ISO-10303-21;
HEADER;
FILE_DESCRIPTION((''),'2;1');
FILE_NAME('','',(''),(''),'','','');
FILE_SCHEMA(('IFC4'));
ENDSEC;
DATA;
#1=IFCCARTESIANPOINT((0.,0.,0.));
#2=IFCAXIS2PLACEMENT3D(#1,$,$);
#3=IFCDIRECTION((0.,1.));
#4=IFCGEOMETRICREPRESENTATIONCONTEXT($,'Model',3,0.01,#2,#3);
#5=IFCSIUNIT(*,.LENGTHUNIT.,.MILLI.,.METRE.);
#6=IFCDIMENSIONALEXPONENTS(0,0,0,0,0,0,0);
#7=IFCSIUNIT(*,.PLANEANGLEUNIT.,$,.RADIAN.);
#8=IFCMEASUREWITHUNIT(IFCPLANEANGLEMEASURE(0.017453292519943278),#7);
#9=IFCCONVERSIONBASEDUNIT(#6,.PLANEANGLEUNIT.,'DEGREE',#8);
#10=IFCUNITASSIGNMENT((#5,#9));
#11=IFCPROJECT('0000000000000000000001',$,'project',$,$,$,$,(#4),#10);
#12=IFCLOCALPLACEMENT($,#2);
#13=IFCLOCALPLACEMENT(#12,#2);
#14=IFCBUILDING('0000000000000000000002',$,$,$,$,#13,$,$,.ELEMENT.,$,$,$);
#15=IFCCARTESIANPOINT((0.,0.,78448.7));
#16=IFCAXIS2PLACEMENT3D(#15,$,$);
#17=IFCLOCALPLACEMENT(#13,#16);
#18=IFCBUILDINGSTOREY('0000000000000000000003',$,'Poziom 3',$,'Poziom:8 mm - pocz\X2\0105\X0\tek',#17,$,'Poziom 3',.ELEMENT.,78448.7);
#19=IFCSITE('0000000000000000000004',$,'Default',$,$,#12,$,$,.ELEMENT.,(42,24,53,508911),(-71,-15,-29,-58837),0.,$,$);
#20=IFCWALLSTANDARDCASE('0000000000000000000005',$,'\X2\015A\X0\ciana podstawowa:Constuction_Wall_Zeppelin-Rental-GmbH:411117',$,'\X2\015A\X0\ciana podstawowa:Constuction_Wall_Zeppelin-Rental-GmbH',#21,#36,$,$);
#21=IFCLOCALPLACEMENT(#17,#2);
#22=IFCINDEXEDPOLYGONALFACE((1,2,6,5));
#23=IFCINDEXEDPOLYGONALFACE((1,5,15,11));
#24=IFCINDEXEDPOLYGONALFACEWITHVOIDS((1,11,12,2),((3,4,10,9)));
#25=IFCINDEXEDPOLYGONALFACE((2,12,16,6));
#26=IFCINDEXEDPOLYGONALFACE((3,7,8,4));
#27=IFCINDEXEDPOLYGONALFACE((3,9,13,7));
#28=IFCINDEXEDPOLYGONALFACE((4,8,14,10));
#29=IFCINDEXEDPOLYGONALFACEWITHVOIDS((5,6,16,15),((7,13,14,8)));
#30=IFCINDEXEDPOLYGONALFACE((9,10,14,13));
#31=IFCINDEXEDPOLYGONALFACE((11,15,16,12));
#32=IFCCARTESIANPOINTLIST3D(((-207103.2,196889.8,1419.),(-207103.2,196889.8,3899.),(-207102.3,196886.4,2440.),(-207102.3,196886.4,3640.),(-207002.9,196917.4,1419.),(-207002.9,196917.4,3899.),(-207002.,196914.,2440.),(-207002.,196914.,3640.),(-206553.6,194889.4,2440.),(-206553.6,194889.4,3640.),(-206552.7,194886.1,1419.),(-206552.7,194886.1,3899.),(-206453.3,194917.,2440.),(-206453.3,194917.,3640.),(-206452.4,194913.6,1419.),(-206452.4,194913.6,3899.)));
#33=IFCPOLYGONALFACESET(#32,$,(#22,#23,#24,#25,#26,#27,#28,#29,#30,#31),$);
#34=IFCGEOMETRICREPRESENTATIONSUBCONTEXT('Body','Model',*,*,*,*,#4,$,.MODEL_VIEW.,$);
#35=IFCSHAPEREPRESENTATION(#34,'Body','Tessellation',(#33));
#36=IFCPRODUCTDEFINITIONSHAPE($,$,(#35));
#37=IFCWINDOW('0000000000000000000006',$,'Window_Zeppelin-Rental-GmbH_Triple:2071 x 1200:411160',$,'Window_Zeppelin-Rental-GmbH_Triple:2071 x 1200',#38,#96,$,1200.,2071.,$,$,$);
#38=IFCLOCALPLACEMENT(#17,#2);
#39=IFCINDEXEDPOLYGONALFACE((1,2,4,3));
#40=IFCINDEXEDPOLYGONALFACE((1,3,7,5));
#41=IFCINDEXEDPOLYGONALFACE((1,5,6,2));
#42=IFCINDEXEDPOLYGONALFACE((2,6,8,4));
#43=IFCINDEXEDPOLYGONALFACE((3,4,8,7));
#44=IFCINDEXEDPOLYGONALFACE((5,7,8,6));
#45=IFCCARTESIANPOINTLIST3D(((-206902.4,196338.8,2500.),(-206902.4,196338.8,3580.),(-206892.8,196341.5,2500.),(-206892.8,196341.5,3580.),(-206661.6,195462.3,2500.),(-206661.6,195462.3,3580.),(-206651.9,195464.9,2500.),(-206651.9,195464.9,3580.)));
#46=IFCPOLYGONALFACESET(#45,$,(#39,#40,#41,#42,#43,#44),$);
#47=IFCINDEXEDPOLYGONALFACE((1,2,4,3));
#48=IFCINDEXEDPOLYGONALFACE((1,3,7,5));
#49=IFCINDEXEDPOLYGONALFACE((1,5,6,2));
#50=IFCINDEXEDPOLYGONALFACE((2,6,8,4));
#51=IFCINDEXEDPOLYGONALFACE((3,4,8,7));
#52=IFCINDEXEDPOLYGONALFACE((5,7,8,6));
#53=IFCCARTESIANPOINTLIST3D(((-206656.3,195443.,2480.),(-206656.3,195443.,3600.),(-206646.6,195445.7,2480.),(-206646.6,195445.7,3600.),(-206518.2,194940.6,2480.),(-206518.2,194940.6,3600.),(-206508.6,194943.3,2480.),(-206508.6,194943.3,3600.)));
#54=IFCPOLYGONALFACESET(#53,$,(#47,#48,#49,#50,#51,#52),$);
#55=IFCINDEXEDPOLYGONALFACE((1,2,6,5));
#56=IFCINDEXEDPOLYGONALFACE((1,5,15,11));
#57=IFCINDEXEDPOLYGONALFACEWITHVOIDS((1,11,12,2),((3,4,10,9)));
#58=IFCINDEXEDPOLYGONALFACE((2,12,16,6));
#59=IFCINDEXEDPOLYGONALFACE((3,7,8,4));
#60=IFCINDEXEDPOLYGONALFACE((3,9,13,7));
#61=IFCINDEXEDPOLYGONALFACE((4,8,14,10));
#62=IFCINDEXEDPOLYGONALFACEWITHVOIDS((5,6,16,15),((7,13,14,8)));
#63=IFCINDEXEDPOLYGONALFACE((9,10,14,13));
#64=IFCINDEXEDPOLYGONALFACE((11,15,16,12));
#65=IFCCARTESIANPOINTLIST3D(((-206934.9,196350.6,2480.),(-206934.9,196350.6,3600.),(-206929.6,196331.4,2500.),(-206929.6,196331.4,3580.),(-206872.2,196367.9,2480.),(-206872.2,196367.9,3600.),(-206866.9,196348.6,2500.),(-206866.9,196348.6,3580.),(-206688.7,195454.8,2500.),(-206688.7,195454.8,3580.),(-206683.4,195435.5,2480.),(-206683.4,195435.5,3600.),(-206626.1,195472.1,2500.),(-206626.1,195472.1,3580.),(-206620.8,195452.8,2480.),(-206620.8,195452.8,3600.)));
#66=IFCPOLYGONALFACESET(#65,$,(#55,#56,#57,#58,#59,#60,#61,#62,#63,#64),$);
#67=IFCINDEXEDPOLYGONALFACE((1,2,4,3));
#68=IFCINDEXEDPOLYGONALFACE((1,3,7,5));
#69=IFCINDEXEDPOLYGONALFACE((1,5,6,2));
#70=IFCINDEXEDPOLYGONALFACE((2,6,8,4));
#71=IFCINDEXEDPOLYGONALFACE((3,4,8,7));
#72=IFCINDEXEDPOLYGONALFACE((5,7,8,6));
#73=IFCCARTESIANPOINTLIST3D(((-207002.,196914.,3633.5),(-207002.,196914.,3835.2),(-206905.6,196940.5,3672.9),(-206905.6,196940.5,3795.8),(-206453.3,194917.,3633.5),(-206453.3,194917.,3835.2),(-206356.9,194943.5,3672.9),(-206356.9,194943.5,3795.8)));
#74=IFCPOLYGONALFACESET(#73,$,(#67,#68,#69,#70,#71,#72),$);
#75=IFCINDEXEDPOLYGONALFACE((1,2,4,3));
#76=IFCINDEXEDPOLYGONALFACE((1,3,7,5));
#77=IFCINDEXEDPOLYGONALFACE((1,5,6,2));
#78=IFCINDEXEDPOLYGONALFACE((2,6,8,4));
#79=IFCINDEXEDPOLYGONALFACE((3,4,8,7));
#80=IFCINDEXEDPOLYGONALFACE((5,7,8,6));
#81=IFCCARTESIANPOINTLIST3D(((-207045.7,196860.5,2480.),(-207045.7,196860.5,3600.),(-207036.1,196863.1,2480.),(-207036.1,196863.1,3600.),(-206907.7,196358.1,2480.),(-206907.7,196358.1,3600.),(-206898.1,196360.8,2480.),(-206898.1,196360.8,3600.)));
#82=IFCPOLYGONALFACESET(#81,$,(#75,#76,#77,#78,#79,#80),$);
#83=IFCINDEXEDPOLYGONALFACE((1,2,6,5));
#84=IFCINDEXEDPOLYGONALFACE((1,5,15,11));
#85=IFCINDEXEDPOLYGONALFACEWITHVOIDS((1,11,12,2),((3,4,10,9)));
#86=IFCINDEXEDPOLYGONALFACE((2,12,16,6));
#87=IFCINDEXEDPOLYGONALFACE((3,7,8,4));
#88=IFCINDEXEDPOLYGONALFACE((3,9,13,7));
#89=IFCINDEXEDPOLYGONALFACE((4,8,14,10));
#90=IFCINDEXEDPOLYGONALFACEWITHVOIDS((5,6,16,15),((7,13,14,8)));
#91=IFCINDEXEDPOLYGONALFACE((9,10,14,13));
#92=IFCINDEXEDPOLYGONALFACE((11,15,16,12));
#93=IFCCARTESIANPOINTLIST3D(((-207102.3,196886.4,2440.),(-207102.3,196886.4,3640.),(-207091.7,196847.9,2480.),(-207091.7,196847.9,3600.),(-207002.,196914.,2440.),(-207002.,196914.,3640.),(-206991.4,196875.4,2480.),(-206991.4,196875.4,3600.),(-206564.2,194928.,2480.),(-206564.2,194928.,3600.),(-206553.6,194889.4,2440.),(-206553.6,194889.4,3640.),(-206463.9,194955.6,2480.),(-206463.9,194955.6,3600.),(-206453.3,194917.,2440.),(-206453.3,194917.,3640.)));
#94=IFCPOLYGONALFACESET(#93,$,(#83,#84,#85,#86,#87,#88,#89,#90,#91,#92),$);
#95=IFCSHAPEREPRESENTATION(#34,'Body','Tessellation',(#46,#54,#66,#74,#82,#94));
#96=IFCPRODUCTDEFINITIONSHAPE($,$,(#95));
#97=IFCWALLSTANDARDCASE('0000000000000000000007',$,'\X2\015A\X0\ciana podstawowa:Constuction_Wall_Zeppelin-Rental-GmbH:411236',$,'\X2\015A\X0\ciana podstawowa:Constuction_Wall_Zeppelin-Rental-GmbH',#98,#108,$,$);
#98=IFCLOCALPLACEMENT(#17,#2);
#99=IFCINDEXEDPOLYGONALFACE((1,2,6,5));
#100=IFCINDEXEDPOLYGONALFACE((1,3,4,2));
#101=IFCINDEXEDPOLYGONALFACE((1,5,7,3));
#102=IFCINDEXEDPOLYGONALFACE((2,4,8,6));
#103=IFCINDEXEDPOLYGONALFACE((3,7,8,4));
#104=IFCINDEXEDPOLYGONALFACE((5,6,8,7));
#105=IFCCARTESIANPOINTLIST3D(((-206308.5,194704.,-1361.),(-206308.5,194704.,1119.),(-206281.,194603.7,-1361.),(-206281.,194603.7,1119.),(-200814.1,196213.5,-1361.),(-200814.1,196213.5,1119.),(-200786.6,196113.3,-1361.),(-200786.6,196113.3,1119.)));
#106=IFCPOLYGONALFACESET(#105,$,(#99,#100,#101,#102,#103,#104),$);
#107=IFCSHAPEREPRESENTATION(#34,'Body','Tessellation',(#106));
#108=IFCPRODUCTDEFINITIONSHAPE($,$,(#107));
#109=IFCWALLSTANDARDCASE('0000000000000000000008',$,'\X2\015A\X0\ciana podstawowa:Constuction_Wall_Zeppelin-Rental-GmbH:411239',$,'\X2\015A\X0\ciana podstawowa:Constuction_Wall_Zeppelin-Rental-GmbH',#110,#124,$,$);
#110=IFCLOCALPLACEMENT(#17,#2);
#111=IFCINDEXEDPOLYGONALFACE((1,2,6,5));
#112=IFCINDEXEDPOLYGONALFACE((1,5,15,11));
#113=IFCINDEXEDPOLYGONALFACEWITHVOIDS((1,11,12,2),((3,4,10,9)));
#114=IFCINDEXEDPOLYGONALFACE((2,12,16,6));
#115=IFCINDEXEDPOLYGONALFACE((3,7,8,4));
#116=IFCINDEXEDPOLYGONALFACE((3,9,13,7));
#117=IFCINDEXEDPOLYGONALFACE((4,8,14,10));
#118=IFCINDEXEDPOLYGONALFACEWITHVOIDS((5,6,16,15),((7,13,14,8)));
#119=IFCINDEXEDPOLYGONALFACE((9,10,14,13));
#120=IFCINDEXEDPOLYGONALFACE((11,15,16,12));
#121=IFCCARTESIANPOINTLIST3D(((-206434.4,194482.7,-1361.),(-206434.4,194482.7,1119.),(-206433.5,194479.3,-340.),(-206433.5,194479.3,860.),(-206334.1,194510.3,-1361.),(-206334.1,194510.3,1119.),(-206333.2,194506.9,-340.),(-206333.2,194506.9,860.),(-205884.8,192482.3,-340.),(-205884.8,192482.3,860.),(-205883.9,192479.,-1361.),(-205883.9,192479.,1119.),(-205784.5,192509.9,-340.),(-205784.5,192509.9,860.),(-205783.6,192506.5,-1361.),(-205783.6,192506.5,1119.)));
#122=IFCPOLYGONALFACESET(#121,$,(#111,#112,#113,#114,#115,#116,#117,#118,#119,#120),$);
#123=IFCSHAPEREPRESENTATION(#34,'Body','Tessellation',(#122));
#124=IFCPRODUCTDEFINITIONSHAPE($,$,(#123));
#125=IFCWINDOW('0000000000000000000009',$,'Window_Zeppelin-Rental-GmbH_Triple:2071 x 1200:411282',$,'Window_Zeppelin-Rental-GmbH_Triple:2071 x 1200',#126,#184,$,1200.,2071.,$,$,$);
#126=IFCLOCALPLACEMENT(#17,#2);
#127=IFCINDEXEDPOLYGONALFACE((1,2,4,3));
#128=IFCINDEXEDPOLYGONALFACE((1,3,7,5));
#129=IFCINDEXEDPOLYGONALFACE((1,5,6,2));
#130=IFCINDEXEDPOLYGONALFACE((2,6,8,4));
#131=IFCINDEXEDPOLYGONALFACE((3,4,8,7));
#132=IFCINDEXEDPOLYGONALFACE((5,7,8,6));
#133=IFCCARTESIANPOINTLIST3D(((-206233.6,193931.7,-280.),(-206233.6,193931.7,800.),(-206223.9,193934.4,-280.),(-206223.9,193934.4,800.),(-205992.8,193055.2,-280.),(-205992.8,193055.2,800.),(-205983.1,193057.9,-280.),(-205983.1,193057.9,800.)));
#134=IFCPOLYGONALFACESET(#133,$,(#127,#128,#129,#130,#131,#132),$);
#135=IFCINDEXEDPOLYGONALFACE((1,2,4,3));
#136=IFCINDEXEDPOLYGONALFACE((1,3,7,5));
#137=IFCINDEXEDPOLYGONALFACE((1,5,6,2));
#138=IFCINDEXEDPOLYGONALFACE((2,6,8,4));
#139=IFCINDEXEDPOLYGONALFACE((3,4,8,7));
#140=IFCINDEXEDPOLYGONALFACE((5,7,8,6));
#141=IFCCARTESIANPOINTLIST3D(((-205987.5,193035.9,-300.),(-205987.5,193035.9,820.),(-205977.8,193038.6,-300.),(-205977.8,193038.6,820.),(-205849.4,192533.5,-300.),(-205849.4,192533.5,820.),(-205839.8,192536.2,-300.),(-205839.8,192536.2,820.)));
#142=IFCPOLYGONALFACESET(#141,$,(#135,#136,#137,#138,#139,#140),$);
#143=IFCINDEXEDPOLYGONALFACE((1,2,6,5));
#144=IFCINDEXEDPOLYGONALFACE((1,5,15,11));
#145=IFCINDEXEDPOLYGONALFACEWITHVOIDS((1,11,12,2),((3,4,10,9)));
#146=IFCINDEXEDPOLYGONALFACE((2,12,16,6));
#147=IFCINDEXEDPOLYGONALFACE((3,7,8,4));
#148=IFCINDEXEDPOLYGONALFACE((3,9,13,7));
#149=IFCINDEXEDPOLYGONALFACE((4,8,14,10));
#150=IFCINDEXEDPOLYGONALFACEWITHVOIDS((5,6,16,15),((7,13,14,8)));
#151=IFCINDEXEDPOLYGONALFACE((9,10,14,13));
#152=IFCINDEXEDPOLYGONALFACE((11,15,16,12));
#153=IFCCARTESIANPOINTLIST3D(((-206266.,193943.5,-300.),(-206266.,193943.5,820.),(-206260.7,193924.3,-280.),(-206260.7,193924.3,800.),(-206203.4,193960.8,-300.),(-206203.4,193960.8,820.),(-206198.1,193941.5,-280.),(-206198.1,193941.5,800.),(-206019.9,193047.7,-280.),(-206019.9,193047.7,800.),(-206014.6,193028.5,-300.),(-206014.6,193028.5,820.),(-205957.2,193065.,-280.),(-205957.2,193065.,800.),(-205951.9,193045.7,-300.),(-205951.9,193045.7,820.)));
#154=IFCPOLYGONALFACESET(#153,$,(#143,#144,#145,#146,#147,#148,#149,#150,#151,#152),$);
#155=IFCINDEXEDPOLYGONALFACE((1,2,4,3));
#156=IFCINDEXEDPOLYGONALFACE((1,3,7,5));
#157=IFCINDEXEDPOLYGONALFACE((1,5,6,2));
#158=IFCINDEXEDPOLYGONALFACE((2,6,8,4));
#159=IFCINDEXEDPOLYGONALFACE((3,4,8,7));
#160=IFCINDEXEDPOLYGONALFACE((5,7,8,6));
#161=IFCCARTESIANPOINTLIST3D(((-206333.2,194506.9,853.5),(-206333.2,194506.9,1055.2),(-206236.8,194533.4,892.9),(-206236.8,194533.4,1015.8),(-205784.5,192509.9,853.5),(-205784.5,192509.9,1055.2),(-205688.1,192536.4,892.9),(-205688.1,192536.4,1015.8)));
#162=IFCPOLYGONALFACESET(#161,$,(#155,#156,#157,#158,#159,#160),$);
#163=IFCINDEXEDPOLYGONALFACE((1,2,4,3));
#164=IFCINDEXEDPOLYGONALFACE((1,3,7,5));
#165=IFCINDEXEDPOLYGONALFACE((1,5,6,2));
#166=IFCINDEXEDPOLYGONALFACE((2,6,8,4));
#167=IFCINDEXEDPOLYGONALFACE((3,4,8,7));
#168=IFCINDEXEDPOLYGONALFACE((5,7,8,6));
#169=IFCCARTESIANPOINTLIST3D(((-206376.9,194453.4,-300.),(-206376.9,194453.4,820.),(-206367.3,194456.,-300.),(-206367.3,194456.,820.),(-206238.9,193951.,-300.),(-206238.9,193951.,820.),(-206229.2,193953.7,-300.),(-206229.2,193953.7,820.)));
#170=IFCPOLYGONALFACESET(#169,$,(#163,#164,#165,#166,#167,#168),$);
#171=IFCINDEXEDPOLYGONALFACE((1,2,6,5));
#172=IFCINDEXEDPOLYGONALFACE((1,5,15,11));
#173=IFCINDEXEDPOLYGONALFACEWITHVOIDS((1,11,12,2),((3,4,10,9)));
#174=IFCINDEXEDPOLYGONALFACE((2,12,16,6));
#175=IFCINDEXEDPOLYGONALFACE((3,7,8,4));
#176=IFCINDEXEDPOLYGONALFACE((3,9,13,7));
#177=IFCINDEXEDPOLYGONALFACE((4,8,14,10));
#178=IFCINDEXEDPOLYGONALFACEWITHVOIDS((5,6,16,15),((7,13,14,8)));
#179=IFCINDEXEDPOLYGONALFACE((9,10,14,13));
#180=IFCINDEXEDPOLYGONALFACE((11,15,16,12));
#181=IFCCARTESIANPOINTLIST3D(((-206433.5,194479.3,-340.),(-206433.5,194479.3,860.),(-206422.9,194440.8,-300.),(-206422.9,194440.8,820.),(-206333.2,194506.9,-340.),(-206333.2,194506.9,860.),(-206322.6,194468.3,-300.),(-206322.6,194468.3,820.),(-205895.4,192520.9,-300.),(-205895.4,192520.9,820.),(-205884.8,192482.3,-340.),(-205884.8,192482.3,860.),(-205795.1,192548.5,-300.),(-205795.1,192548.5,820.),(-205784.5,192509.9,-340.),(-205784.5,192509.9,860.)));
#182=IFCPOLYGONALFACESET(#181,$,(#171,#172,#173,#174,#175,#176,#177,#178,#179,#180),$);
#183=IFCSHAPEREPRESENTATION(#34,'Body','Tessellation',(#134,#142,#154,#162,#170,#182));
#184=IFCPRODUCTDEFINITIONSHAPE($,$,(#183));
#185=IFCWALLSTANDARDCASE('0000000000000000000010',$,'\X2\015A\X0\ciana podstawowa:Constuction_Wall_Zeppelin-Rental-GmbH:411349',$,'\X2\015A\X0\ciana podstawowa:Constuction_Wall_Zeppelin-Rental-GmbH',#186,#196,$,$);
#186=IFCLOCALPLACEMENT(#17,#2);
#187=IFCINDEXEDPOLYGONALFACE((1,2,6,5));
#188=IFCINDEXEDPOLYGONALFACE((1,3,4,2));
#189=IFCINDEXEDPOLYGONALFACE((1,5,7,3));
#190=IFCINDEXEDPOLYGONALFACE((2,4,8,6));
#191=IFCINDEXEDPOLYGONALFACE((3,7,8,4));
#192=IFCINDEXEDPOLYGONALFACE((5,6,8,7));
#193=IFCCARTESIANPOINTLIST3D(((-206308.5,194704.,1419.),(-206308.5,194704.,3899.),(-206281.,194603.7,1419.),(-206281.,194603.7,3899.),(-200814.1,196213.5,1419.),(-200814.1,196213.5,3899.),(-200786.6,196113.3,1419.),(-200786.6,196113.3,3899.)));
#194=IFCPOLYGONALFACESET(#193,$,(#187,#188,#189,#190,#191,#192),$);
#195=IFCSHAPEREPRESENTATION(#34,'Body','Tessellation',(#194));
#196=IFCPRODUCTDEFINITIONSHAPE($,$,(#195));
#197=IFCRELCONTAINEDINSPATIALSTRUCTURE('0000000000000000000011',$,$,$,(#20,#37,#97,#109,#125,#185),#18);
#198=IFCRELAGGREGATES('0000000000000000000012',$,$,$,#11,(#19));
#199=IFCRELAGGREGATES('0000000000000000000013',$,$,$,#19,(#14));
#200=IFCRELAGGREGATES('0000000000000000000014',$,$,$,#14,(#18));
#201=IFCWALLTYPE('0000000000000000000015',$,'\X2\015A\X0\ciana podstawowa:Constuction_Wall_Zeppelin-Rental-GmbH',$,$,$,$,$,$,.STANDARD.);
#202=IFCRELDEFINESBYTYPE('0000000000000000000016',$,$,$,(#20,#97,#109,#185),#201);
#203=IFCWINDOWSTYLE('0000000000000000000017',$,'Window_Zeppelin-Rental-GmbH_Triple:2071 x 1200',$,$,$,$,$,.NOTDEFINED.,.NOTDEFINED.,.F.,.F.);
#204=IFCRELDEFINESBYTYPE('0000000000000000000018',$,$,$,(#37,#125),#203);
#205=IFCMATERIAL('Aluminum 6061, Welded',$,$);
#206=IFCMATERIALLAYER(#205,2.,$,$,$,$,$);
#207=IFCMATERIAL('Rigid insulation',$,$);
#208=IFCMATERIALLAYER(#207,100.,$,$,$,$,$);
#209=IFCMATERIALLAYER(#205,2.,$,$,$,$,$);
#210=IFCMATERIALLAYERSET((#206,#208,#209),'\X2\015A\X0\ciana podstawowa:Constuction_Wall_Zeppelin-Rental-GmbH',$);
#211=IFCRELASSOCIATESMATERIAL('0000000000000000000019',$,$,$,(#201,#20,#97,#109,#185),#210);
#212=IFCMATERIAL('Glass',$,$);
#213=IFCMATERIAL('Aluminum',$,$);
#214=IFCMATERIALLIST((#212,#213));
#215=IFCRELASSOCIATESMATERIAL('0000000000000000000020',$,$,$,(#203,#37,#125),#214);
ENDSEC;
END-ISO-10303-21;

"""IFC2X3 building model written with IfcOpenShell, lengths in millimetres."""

from ifc_helpers import new_model, entity, si_unit, converted_unit, direction, frame, frame_2d, origin, origin_2d_with_axis, place, context, subcontext, project, spatial, polyline, rectangle, outline, extrude, source, transform, mapped, material, material_list, layer, layer_set, layer_usage, type_object, type_shapes, element, fill, save


model = new_model("IFC2X3")

# Units and contexts
model_context = context("Model", 3, precision=0.01, world=origin(), true_north=direction((0.0, 1.0)))
body_context = subcontext(model_context, "Body", "Model", "MODEL_VIEW")
ifc_project = project(units=[si_unit("LENGTHUNIT", "METRE", prefix="MILLI"), converted_unit("PLANEANGLEUNIT", "DEGREE", entity("IfcPlaneAngleMeasure", 0.017453292519943278), si_unit("PLANEANGLEUNIT", "RADIAN"), dimensions=[0, 0, 0, 0, 0, 0, 0])], contexts=[model_context])

# Site, building, storey
site_placement = place(None, origin())
site = spatial("IfcSite", under=ifc_project, at=site_placement, Name="Default", CompositionType="ELEMENT", RefLatitude=(42, 24, 53, 508911), RefLongitude=(-71, -15, -29, -58837), RefElevation=0.0)
building_placement = place(site_placement, origin())
building = spatial("IfcBuilding", under=site, at=building_placement, CompositionType="ELEMENT")
storey_placement = place(building_placement, frame((0.0, 0.0, 78448.7)))
storey = spatial("IfcBuildingStorey", under=building, at=storey_placement, Name="Poziom 3", ObjectType="Poziom:8 mm - początek", LongName="Poziom 3", CompositionType="ELEMENT", Elevation=78448.7)

# Shared definitions
ifc_material_1 = material(Name="Aluminum 6061, Welded")
ifc_layer_1 = layer(ifc_material_1, 2.0)
ifc_material_2 = material(Name="Rigid insulation")
ifc_layer_2 = layer(ifc_material_2, 100.0)
ifc_layer_3 = layer(ifc_material_1, 2.0)
ifc_layer_set_1 = layer_set([ifc_layer_1, ifc_layer_2, ifc_layer_3], Name="Ściana podstawowa:Constuction_Wall_Zeppelin-Rental-GmbH")
wall_type_1 = type_object("IfcWallType", Name="Ściana podstawowa:Constuction_Wall_Zeppelin-Rental-GmbH", PredefinedType="STANDARD", material=ifc_layer_set_1)

# Shared definitions
ifc_material_3 = material(Name="Glass")
ifc_material_4 = material(Name="Aluminum")
ifc_material_list = material_list([ifc_material_3, ifc_material_4])
window_style = type_object("IfcWindowStyle", Name="Window_Zeppelin-Rental-GmbH_Triple:2071 x 1200", ConstructionType="NOTDEFINED", OperationType="NOTDEFINED", ParameterTakesPrecedence=False, Sizeable=False, material=ifc_material_list)
shared_shape_1 = source(origin(), body_context, "Body", "SweptSolid", [
    extrude(rectangle(XDim=10.0, YDim=909.0, at=origin_2d_with_axis()), frame((1035.5, 52.7, 60.0), z_axis=(0.0, 0.0, 1.0), x_axis=(0.0, -1.0, 0.0)), (0.0, 0.0, 1.0), 1080.0),
    extrude(rectangle(XDim=521.0, YDim=10.0, at=frame_2d((0.0, 0.0), x_axis=(1.0, 0.0))), frame((300.5, 52.7, 40.0), z_axis=(0.0, 0.0, 1.0), x_axis=(-1.0, 0.0, 0.0)), (0.0, 0.0, 1.0), 1120.0),
    extrude(outline(polyline([(-474.5, -560.0), (474.5, -560.0), (474.5, 560.0), (-474.5, 560.0), (-474.5, -560.0)]), holes=[polyline([(-454.5, 540.0), (454.5, 540.0), (454.5, -540.0), (-454.5, -540.0), (-454.5, 540.0)])]), frame((1035.5, 85.8, 600.0), z_axis=(0.0, -1.0, 0.0), x_axis=(1.0, 0.0, 0.0)), (0.0, 0.0, 1.0), 65.0),
    extrude(outline(polyline([(-24.0, -75.5), (83.5, -75.5), (9.6, 112.1), (-69.0, 38.9), (-24.0, -75.5)])), frame((2071.0, -48.7, 1294.4), z_axis=(-1.0, 0.0, 0.0), x_axis=(0.0, 0.930458, 0.366398)), (0.0, 0.0, 1.0), 2071.0),
    extrude(rectangle(XDim=10.0, YDim=521.0, at=frame_2d((0.0, 0.0), x_axis=(1.0, 0.0))), frame((1770.5, 52.7, 40.0), z_axis=(0.0, 0.0, 1.0), x_axis=(0.0, -1.0, 0.0)), (0.0, 0.0, 1.0), 1120.0),
    extrude(outline(polyline([(-1035.5, -600.0), (1035.5, -600.0), (1035.5, 600.0), (-1035.5, 600.0), (-1035.5, -600.0)]), holes=[polyline([(-995.5, 560.0), (995.5, 560.0), (995.5, -560.0), (-995.5, -560.0), (-995.5, 560.0)])]), frame((1035.5, 105.3, 600.0), z_axis=(0.0, -1.0, 0.0), x_axis=(1.0, 0.0, 0.0)), (0.0, 0.0, 1.0), 104.0),
])
type_shapes(window_style, [shared_shape_1])

# Wall, opening, window
ifc_layer_usage_1 = layer_usage(ifc_layer_set_1, "AXIS2", "NEGATIVE", 52.0)
wall_1_placement = place(storey_placement, frame((-206502.5, 194899.8, 1419.0), z_axis=(0.0, 0.0, 1.0), x_axis=(-0.264931, 0.964267, 0.0)))
wall_1 = element("IfcWallStandardCase", 1, at=wall_1_placement, inside=storey, type_object=wall_type_1, material=ifc_layer_usage_1, Name="Ściana podstawowa:Constuction_Wall_Zeppelin-Rental-GmbH:411117", ObjectType="Ściana podstawowa:Constuction_Wall_Zeppelin-Rental-GmbH", context=body_context, shape_type="SweptSolid", body=[
    extrude(rectangle(XDim=2078.0, YDim=104.0, at=frame_2d((1039.0, 0.0), x_axis=(-1.0, 0.0))), origin(), (0.0, 0.0, 1.0), 2480.0),
])
opening_1_placement = place(wall_1_placement, frame((3.5, -52.0, 1021.0)))
opening_1 = element("IfcOpeningElement", 2, at=opening_1_placement, cuts=wall_1, ObjectType="Opening", context=body_context, shape_type="SweptSolid", body=[
    extrude(rectangle(XDim=1200.0, YDim=2071.0, at=frame_2d((600.0, 1035.5), x_axis=(1.0, 0.0))), frame((0.0, 0.0, 0.0), z_axis=(0.0, 1.0, 0.0), x_axis=(0.0, 0.0, 1.0)), (0.0, 0.0, 1.0), 104.0),
])
window_1_placement = place(opening_1_placement, frame((0.0, -1.3, 0.0)))
window_1 = element("IfcWindow", 3, at=window_1_placement, inside=storey, type_object=window_style, material=ifc_material_list, Name="Window_Zeppelin-Rental-GmbH_Triple:2071 x 1200:411160", ObjectType="Window_Zeppelin-Rental-GmbH_Triple:2071 x 1200", OverallHeight=1200.0, OverallWidth=2071.0, context=body_context, shape_type="MappedRepresentation", body=[
    mapped(shared_shape_1, transform((0.0, 0.0, 0.0), scale=1.0)),
])
fill(opening_1, window_1)

# Wall
ifc_layer_usage_2 = layer_usage(ifc_layer_set_1, "AXIS2", "NEGATIVE", 52.0)
wall_2_placement = place(storey_placement, frame((-206294.7, 194653.8, -1361.0), z_axis=(0.0, 0.0, 1.0), x_axis=(0.964267, 0.264931, 0.0)))
element("IfcWallStandardCase", 4, at=wall_2_placement, inside=storey, type_object=wall_type_1, material=ifc_layer_usage_2, Name="Ściana podstawowa:Constuction_Wall_Zeppelin-Rental-GmbH:411236", ObjectType="Ściana podstawowa:Constuction_Wall_Zeppelin-Rental-GmbH", context=body_context, shape_type="SweptSolid", body=[
    extrude(rectangle(XDim=5698.0, YDim=104.0, at=frame_2d((2849.0, 0.0), x_axis=(-1.0, 0.0))), origin(), (0.0, 0.0, 1.0), 2480.0),
])

# Wall, opening, window
ifc_layer_usage_3 = layer_usage(ifc_layer_set_1, "AXIS2", "NEGATIVE", 52.0)
wall_3_placement = place(storey_placement, frame((-205833.7, 192492.7, -1361.0), z_axis=(0.0, 0.0, 1.0), x_axis=(-0.264931, 0.964267, 0.0)))
wall_3 = element("IfcWallStandardCase", 5, at=wall_3_placement, inside=storey, type_object=wall_type_1, material=ifc_layer_usage_3, Name="Ściana podstawowa:Constuction_Wall_Zeppelin-Rental-GmbH:411239", ObjectType="Ściana podstawowa:Constuction_Wall_Zeppelin-Rental-GmbH", context=body_context, shape_type="SweptSolid", body=[
    extrude(rectangle(XDim=2078.0, YDim=104.0, at=frame_2d((1039.0, 0.0), x_axis=(-1.0, 0.0))), origin(), (0.0, 0.0, 1.0), 2480.0),
])
opening_2_placement = place(wall_3_placement, frame((3.5, -52.0, 1021.0)))
opening_2 = element("IfcOpeningElement", 6, at=opening_2_placement, cuts=wall_3, ObjectType="Opening", context=body_context, shape_type="SweptSolid", body=[
    extrude(rectangle(XDim=1200.0, YDim=2071.0, at=frame_2d((600.0, 1035.5), x_axis=(1.0, 0.0))), frame((0.0, 0.0, 0.0), z_axis=(0.0, 1.0, 0.0), x_axis=(0.0, 0.0, 1.0)), (0.0, 0.0, 1.0), 104.0),
])
window_2_placement = place(opening_2_placement, frame((0.0, -1.3, 0.0)))
window_2 = element("IfcWindow", 7, at=window_2_placement, inside=storey, type_object=window_style, material=ifc_material_list, Name="Window_Zeppelin-Rental-GmbH_Triple:2071 x 1200:411282", ObjectType="Window_Zeppelin-Rental-GmbH_Triple:2071 x 1200", OverallHeight=1200.0, OverallWidth=2071.0, context=body_context, shape_type="MappedRepresentation", body=[
    mapped(shared_shape_1, transform((0.0, 0.0, 0.0), scale=1.0)),
])
fill(opening_2, window_2)

# Wall
ifc_layer_usage_4 = layer_usage(ifc_layer_set_1, "AXIS2", "NEGATIVE", 52.0)
wall_4_placement = place(storey_placement, frame((-206294.7, 194653.8, 1419.0), z_axis=(0.0, 0.0, 1.0), x_axis=(0.964267, 0.264931, 0.0)))
element("IfcWallStandardCase", 8, at=wall_4_placement, inside=storey, type_object=wall_type_1, material=ifc_layer_usage_4, Name="Ściana podstawowa:Constuction_Wall_Zeppelin-Rental-GmbH:411349", ObjectType="Ściana podstawowa:Constuction_Wall_Zeppelin-Rental-GmbH", context=body_context, shape_type="SweptSolid", body=[
    extrude(rectangle(XDim=5698.0, YDim=104.0, at=frame_2d((2849.0, 0.0), x_axis=(-1.0, 0.0))), origin(), (0.0, 0.0, 1.0), 2480.0),
])

save(model, "model.ifc")
